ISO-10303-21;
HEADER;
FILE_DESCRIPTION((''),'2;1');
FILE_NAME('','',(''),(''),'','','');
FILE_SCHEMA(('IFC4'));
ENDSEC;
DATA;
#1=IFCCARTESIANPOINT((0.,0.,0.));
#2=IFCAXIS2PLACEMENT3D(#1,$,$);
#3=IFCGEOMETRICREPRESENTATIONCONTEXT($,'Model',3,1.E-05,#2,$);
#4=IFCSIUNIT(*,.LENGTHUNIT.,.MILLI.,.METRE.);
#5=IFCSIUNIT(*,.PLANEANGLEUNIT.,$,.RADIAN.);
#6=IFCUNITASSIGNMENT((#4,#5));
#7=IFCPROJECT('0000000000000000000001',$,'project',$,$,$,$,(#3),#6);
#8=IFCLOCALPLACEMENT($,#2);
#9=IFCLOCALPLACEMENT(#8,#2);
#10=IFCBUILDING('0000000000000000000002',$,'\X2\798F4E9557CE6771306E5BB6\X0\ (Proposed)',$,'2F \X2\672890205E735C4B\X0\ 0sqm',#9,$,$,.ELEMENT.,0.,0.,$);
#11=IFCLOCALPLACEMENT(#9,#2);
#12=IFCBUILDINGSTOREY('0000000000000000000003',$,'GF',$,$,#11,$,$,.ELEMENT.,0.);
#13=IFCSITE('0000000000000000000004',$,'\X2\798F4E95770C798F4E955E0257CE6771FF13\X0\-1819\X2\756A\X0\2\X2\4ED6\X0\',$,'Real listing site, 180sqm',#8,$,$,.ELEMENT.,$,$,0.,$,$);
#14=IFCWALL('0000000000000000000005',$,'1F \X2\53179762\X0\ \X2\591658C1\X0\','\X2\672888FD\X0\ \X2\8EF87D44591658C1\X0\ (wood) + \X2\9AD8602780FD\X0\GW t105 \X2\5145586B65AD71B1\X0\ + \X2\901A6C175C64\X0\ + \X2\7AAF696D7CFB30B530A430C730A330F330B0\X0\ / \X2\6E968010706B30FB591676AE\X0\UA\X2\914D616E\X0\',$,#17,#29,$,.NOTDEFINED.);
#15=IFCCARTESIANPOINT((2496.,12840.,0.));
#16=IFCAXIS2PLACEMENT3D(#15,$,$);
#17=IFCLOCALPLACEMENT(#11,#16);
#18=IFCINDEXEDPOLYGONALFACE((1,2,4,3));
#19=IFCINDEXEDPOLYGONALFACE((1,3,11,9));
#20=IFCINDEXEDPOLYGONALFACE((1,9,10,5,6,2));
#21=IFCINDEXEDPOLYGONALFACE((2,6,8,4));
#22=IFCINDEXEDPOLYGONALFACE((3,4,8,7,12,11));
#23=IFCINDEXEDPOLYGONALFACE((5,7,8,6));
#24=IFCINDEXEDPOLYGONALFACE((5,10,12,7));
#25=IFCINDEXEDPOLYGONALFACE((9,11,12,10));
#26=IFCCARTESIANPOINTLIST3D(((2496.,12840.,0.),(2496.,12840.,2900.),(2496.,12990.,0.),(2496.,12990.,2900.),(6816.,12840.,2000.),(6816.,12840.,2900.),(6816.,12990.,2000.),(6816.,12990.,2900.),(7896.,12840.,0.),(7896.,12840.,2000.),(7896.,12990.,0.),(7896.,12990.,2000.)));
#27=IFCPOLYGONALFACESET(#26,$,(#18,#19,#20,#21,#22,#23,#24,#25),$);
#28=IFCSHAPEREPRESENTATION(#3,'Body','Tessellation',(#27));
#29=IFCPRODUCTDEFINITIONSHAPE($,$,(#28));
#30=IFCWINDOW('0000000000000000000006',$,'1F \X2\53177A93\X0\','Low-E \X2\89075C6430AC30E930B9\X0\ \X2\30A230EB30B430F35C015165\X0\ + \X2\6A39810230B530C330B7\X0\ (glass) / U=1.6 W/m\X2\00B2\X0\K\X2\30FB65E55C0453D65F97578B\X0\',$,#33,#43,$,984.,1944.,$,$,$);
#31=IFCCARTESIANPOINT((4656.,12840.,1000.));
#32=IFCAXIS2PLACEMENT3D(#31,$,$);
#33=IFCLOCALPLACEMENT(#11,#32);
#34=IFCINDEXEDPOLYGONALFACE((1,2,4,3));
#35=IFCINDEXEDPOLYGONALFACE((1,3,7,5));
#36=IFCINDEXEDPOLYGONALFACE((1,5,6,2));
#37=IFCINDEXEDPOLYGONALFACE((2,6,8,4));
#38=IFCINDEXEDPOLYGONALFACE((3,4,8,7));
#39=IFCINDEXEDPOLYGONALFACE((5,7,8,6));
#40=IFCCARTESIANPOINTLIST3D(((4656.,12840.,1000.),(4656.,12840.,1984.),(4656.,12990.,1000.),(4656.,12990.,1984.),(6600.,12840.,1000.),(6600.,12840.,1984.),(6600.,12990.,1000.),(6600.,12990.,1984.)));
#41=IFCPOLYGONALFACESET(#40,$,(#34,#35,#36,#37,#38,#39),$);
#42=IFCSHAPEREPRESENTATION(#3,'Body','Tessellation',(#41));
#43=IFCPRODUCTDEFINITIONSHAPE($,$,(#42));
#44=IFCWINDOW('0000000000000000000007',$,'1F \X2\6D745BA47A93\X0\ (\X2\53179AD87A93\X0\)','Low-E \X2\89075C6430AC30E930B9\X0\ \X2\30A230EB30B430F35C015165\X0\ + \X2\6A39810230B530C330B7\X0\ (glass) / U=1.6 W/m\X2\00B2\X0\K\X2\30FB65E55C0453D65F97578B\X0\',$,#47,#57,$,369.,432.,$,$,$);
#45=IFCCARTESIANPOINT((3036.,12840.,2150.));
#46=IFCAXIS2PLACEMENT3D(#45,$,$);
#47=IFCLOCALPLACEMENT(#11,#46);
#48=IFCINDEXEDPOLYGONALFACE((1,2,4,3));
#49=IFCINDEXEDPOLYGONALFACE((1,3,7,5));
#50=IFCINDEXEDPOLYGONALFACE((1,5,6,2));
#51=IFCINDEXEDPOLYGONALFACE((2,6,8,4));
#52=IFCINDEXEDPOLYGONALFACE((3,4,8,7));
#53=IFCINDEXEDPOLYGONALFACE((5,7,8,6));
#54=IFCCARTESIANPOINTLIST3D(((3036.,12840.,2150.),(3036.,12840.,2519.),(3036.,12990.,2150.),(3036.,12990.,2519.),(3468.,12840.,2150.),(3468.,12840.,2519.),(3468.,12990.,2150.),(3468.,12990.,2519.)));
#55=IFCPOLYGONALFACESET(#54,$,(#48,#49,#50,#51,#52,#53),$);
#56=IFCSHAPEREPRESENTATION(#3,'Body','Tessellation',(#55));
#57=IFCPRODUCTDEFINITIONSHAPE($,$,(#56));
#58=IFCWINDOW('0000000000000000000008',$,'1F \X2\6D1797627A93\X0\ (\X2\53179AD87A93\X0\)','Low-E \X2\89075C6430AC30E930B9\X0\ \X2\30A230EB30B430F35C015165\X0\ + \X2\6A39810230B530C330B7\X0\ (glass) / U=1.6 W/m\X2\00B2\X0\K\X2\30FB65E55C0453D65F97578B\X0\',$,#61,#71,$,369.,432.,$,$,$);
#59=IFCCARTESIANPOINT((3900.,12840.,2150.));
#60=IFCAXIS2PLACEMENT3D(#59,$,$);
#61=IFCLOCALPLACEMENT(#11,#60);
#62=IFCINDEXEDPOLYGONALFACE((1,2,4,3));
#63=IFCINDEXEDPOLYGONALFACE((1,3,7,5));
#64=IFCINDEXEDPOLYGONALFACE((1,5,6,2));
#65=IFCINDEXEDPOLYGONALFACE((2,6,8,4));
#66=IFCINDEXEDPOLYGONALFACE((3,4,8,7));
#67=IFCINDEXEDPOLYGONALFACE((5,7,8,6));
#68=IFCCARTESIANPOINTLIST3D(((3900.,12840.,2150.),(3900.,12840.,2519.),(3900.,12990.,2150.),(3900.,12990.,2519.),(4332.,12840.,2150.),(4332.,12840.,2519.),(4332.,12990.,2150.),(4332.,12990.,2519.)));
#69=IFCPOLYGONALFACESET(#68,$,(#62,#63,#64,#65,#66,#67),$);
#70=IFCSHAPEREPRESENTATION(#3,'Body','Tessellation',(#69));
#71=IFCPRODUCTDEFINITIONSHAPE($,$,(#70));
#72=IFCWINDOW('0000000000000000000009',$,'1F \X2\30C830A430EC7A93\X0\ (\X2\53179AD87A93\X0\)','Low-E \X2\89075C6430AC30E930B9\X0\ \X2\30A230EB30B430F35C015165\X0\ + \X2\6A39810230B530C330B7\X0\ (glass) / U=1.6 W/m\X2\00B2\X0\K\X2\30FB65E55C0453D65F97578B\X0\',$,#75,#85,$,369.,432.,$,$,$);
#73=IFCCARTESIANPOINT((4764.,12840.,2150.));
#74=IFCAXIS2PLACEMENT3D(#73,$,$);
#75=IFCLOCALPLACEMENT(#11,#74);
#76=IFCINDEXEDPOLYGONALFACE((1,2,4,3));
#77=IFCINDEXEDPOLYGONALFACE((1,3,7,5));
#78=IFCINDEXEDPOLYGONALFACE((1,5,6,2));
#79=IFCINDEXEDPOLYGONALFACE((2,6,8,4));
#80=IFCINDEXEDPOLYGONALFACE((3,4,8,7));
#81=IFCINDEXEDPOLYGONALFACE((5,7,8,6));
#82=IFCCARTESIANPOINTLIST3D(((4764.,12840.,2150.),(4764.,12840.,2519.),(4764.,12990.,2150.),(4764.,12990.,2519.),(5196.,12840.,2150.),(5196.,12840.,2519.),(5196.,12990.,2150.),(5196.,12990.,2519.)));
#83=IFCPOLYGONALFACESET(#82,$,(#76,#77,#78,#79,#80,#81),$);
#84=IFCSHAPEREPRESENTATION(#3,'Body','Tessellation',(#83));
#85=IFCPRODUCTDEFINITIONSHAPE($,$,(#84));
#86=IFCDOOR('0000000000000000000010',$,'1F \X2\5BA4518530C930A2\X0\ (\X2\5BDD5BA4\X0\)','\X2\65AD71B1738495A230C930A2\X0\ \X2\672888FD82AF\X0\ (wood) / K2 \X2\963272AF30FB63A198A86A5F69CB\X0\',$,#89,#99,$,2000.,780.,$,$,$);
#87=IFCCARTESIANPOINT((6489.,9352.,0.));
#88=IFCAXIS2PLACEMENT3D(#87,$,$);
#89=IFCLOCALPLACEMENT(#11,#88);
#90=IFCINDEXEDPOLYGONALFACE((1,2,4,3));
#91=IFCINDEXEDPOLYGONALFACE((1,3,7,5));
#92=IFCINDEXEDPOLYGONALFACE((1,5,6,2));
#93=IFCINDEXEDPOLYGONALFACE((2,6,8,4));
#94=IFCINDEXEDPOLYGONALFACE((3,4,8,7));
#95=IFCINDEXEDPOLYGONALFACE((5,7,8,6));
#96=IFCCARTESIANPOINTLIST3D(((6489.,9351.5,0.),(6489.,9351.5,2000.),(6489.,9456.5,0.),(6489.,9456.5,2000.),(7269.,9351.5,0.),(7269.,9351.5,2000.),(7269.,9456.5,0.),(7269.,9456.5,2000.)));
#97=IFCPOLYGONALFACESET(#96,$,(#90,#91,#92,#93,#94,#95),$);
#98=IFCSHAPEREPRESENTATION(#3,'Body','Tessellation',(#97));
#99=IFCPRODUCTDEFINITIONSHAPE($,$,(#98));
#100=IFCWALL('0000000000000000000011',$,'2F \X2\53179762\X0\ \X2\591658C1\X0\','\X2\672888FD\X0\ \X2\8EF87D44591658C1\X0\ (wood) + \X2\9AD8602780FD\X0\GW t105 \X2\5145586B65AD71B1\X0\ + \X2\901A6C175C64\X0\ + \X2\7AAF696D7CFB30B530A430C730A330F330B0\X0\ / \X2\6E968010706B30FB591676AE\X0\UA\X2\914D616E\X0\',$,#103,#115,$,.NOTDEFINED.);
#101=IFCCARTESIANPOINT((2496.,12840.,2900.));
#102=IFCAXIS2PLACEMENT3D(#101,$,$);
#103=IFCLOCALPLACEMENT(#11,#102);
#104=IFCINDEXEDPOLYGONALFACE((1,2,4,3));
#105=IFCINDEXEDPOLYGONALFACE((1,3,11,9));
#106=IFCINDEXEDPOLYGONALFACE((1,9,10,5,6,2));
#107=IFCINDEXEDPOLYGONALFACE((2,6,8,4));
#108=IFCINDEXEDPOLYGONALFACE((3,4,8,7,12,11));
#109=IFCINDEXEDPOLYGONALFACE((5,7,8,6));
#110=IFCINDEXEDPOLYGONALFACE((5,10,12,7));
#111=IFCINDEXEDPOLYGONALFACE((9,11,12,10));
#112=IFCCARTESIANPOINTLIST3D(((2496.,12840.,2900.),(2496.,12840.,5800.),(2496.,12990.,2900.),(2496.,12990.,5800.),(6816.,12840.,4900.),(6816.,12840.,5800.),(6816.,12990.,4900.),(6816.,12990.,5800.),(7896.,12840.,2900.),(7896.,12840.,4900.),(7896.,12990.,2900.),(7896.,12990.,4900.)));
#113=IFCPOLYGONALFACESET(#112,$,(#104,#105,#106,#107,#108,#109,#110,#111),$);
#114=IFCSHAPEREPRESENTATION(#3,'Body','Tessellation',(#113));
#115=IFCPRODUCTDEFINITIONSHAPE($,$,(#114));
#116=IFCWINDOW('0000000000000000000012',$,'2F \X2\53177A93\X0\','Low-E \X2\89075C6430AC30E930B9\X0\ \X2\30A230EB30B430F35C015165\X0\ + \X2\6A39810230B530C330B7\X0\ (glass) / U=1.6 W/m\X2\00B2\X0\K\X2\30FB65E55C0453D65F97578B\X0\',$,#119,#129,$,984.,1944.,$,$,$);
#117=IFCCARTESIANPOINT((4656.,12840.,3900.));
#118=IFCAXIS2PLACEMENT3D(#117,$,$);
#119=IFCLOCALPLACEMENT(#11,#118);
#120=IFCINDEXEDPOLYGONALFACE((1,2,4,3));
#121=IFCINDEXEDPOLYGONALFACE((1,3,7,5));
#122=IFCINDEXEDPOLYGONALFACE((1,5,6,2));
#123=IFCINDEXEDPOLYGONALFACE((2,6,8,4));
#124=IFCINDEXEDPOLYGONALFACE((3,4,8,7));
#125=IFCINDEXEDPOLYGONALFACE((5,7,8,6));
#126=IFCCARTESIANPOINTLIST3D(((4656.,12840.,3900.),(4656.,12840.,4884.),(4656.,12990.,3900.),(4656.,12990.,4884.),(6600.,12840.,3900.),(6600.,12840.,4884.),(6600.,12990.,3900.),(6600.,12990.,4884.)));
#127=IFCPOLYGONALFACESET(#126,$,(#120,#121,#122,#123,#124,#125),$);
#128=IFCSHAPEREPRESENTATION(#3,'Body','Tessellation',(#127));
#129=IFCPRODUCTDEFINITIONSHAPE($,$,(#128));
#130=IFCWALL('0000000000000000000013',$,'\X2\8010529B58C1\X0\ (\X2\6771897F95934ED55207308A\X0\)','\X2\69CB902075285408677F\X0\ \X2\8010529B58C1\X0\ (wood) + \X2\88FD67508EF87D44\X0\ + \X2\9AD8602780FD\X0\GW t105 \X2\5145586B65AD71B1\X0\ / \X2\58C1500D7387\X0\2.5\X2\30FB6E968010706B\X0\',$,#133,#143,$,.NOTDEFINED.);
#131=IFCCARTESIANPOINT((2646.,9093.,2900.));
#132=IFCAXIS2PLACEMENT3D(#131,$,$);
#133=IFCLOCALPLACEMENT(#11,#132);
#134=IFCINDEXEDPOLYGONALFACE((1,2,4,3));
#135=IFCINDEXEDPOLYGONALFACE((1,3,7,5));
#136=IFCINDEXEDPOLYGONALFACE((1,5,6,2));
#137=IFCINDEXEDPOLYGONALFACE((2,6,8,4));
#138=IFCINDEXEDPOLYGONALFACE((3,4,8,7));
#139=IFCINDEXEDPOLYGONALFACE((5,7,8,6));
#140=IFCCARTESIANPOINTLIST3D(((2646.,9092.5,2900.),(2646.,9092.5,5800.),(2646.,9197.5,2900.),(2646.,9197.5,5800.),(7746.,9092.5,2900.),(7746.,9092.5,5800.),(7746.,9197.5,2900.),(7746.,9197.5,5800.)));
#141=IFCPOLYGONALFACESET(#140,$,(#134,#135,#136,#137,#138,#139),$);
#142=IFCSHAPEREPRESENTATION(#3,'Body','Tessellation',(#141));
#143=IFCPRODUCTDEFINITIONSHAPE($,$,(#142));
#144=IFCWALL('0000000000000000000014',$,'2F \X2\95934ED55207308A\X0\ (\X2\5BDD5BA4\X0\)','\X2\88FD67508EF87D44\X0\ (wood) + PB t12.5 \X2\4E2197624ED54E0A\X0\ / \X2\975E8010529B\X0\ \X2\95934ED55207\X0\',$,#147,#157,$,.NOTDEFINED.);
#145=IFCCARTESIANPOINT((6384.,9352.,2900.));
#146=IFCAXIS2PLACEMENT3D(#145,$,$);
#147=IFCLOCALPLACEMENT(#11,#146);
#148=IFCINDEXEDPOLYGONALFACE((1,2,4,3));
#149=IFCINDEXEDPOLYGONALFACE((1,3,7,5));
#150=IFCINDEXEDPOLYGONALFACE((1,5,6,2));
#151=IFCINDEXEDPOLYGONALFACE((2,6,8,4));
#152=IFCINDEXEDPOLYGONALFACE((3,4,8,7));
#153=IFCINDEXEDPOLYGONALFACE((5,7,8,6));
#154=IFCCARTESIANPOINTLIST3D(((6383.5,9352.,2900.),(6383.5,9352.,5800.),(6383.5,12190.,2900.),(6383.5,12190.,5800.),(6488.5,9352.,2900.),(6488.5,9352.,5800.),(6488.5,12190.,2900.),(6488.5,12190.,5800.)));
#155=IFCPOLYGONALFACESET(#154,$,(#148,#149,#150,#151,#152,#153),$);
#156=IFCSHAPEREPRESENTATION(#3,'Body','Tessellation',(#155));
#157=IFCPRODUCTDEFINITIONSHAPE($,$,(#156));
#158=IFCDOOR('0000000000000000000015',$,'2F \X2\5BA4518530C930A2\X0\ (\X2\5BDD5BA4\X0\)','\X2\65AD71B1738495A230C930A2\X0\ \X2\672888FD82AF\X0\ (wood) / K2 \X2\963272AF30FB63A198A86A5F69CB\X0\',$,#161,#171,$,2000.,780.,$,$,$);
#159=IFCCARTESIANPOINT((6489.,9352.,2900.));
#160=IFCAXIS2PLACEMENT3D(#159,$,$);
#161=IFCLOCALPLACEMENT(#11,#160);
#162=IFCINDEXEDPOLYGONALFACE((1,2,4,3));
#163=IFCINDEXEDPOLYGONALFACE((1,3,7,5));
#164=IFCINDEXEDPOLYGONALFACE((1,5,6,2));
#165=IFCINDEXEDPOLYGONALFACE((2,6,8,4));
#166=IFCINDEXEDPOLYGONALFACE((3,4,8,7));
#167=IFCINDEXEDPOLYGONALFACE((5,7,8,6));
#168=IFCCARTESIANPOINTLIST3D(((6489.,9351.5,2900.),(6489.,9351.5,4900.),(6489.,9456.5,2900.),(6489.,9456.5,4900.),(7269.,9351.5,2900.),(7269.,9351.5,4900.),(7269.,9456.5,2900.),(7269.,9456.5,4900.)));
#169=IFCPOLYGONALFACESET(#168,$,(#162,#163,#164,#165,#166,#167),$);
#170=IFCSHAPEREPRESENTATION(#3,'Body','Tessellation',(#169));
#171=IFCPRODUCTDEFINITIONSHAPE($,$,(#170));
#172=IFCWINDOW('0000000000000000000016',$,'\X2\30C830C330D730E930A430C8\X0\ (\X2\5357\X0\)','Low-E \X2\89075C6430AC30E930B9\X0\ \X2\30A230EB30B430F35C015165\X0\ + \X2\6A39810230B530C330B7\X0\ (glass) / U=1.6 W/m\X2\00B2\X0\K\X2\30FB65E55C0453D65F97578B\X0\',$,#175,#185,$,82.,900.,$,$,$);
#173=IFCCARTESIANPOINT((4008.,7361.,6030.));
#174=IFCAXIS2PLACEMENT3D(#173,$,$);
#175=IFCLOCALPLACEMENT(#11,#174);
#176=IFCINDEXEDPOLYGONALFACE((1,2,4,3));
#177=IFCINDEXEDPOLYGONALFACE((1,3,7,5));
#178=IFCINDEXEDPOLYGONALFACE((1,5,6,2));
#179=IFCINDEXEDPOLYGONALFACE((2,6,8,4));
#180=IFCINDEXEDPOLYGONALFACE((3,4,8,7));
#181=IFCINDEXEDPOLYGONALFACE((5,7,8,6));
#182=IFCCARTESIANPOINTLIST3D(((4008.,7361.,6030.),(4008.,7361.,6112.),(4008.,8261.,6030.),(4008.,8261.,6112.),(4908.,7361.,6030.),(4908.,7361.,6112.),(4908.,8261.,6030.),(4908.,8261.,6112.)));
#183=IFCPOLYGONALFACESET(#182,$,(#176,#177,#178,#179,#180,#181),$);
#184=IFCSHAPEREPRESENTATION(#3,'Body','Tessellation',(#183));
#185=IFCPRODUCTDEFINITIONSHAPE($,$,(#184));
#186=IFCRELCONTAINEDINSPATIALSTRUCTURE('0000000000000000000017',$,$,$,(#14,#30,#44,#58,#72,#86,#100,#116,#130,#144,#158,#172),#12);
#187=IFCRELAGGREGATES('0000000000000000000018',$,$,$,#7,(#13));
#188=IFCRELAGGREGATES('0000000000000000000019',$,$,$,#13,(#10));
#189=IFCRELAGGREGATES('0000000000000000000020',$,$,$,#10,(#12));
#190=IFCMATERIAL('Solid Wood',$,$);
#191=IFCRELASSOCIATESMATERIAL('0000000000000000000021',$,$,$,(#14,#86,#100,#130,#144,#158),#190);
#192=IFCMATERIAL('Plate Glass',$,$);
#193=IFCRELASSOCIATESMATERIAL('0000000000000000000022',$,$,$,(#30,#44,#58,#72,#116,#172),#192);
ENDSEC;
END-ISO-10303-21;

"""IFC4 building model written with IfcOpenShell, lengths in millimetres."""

from ifc_helpers import new_model, si_unit, frame, frame_2d, origin, place, context, project, spatial, rectangle, extrude, material, element, fill, save


model = new_model("IFC4")

# Units and contexts
model_context = context("Model", 3, precision=1e-05, world=origin())
ifc_project = project(units=[si_unit("LENGTHUNIT", "METRE", prefix="MILLI"), si_unit("PLANEANGLEUNIT", "RADIAN")], contexts=[model_context])

# Site, building, storey
site_placement = place(None, origin())
site = spatial("IfcSite", under=ifc_project, at=site_placement, Name="福井県福井市城東３-1819番2他", ObjectType="Real listing site, 180sqm", CompositionType="ELEMENT", RefElevation=0.0)
building_placement = place(site_placement, origin())
building = spatial("IfcBuilding", under=site, at=building_placement, Name="福井城東の家 (Proposed)", ObjectType="2F 木造平屋 0sqm", CompositionType="ELEMENT", ElevationOfRefHeight=0.0, ElevationOfTerrain=0.0)
storey_placement = place(building_placement, origin())
storey = spatial("IfcBuildingStorey", under=building, at=storey_placement, Name="GF", CompositionType="ELEMENT", Elevation=0.0)

# Wall, openings, windows
ifc_material_1 = material(Name="Solid Wood")
wall_1_placement = place(storey_placement, frame((2496.0, 12840.0, 0.0)))
wall_1 = element("IfcWall", 1, at=wall_1_placement, inside=storey, material=ifc_material_1, Name="1F 北面 外壁", Description="木製 軸組外壁 (wood) + 高性能GW t105 充填断熱 + 通気層 + 窯業系サイディング / 準耐火・外皮UA配慮", PredefinedType="NOTDEFINED", context=model_context, shape_type="SweptSolid", body=[
    extrude(rectangle(XDim=5400.0, YDim=150.0, at=frame_2d((2700.0, 75.0))), frame((2496.0, 12840.0, 0.0)), (0.0, 0.0, 1.0), 2900.0),
])
opening_1_placement = place(storey_placement, frame((4656.0, 12840.0, 1000.0)))
opening_1 = element("IfcOpeningElement", 2, at=opening_1_placement, cuts=wall_1, PredefinedType="NOTDEFINED", context=model_context, shape_type="SweptSolid", body=[
    extrude(rectangle(XDim=1944.0, YDim=150.0, at=frame_2d((972.0, 75.0))), frame((4656.0, 12840.0, 1000.0)), (0.0, 0.0, 1.0), 984.0),
])
opening_2_placement = place(storey_placement, frame((3036.0, 12840.0, 2150.0)))
opening_2 = element("IfcOpeningElement", 3, at=opening_2_placement, cuts=wall_1, PredefinedType="NOTDEFINED", context=model_context, shape_type="SweptSolid", body=[
    extrude(rectangle(XDim=432.0, YDim=150.0, at=frame_2d((216.0, 75.0))), frame((3036.0, 12840.0, 2150.0)), (0.0, 0.0, 1.0), 369.0),
])
opening_3_placement = place(storey_placement, frame((3900.0, 12840.0, 2150.0)))
opening_3 = element("IfcOpeningElement", 4, at=opening_3_placement, cuts=wall_1, PredefinedType="NOTDEFINED", context=model_context, shape_type="SweptSolid", body=[
    extrude(rectangle(XDim=432.0, YDim=150.0, at=frame_2d((216.0, 75.0))), frame((3900.0, 12840.0, 2150.0)), (0.0, 0.0, 1.0), 369.0),
])
opening_4_placement = place(storey_placement, frame((4764.0, 12840.0, 2150.0)))
opening_4 = element("IfcOpeningElement", 5, at=opening_4_placement, cuts=wall_1, PredefinedType="NOTDEFINED", context=model_context, shape_type="SweptSolid", body=[
    extrude(rectangle(XDim=432.0, YDim=150.0, at=frame_2d((216.0, 75.0))), frame((4764.0, 12840.0, 2150.0)), (0.0, 0.0, 1.0), 369.0),
])
ifc_material_2 = material(Name="Plate Glass")
window_1_placement = place(storey_placement, frame((4656.0, 12840.0, 1000.0)))
window_1 = element("IfcWindow", 6, at=window_1_placement, inside=storey, material=ifc_material_2, Name="1F 北窓", Description="Low-E 複層ガラス アルゴン封入 + 樹脂サッシ (glass) / U=1.6 W/m²K・日射取得型", OverallHeight=984.0, OverallWidth=1944.0, context=model_context, shape_type="SweptSolid", body=[
    extrude(rectangle(XDim=1944.0, YDim=150.0, at=frame_2d((972.0, 75.0))), frame((4656.0, 12840.0, 1000.0)), (0.0, 0.0, 1.0), 984.0),
])
fill(opening_1, window_1)
window_2_placement = place(storey_placement, frame((3036.0, 12840.0, 2150.0)))
window_2 = element("IfcWindow", 7, at=window_2_placement, inside=storey, material=ifc_material_2, Name="1F 浴室窓 (北高窓)", Description="Low-E 複層ガラス アルゴン封入 + 樹脂サッシ (glass) / U=1.6 W/m²K・日射取得型", OverallHeight=369.0, OverallWidth=432.0, context=model_context, shape_type="SweptSolid", body=[
    extrude(rectangle(XDim=432.0, YDim=150.0, at=frame_2d((216.0, 75.0))), frame((3036.0, 12840.0, 2150.0)), (0.0, 0.0, 1.0), 369.0),
])
fill(opening_2, window_2)
window_3_placement = place(storey_placement, frame((3900.0, 12840.0, 2150.0)))
window_3 = element("IfcWindow", 8, at=window_3_placement, inside=storey, material=ifc_material_2, Name="1F 洗面窓 (北高窓)", Description="Low-E 複層ガラス アルゴン封入 + 樹脂サッシ (glass) / U=1.6 W/m²K・日射取得型", OverallHeight=369.0, OverallWidth=432.0, context=model_context, shape_type="SweptSolid", body=[
    extrude(rectangle(XDim=432.0, YDim=150.0, at=frame_2d((216.0, 75.0))), frame((3900.0, 12840.0, 2150.0)), (0.0, 0.0, 1.0), 369.0),
])
fill(opening_3, window_3)
window_4_placement = place(storey_placement, frame((4764.0, 12840.0, 2150.0)))
window_4 = element("IfcWindow", 9, at=window_4_placement, inside=storey, material=ifc_material_2, Name="1F トイレ窓 (北高窓)", Description="Low-E 複層ガラス アルゴン封入 + 樹脂サッシ (glass) / U=1.6 W/m²K・日射取得型", OverallHeight=369.0, OverallWidth=432.0, context=model_context, shape_type="SweptSolid", body=[
    extrude(rectangle(XDim=432.0, YDim=150.0, at=frame_2d((216.0, 75.0))), frame((4764.0, 12840.0, 2150.0)), (0.0, 0.0, 1.0), 369.0),
])
fill(opening_4, window_4)

# Door
door_1_placement = place(storey_placement, frame((6489.0, 9352.0, 0.0)))
element("IfcDoor", 10, at=door_1_placement, inside=storey, material=ifc_material_1, Name="1F 室内ドア (寝室)", Description="断熱玄関ドア 木製芯 (wood) / K2 防犯・採風機構", OverallHeight=2000.0, OverallWidth=780.0, context=model_context, shape_type="SweptSolid", body=[
    extrude(rectangle(XDim=780.0, YDim=105.0, at=frame_2d((390.0, 52.0))), frame((6489.0, 9352.0, 0.0)), (0.0, 0.0, 1.0), 2000.0),
])

# Wall, opening, window
wall_2_placement = place(storey_placement, frame((2496.0, 12840.0, 2900.0)))
wall_2 = element("IfcWall", 11, at=wall_2_placement, inside=storey, material=ifc_material_1, Name="2F 北面 外壁", Description="木製 軸組外壁 (wood) + 高性能GW t105 充填断熱 + 通気層 + 窯業系サイディング / 準耐火・外皮UA配慮", PredefinedType="NOTDEFINED", context=model_context, shape_type="SweptSolid", body=[
    extrude(rectangle(XDim=5400.0, YDim=150.0, at=frame_2d((2700.0, 75.0))), frame((2496.0, 12840.0, 2900.0)), (0.0, 0.0, 1.0), 2900.0),
])
opening_5_placement = place(storey_placement, frame((4656.0, 12840.0, 3900.0)))
opening_5 = element("IfcOpeningElement", 12, at=opening_5_placement, cuts=wall_2, PredefinedType="NOTDEFINED", context=model_context, shape_type="SweptSolid", body=[
    extrude(rectangle(XDim=1944.0, YDim=150.0, at=frame_2d((972.0, 75.0))), frame((4656.0, 12840.0, 3900.0)), (0.0, 0.0, 1.0), 984.0),
])
window_5_placement = place(storey_placement, frame((4656.0, 12840.0, 3900.0)))
window_5 = element("IfcWindow", 13, at=window_5_placement, inside=storey, material=ifc_material_2, Name="2F 北窓", Description="Low-E 複層ガラス アルゴン封入 + 樹脂サッシ (glass) / U=1.6 W/m²K・日射取得型", OverallHeight=984.0, OverallWidth=1944.0, context=model_context, shape_type="SweptSolid", body=[
    extrude(rectangle(XDim=1944.0, YDim=150.0, at=frame_2d((972.0, 75.0))), frame((4656.0, 12840.0, 3900.0)), (0.0, 0.0, 1.0), 984.0),
])
fill(opening_5, window_5)

# Walls
wall_3_placement = place(storey_placement, frame((2646.0, 9093.0, 2900.0)))
element("IfcWall", 14, at=wall_3_placement, inside=storey, material=ifc_material_1, Name="耐力壁 (東西間仕切り)", Description="構造用合板 耐力壁 (wood) + 製材軸組 + 高性能GW t105 充填断熱 / 壁倍率2.5・準耐火", PredefinedType="NOTDEFINED", context=model_context, shape_type="SweptSolid", body=[
    extrude(rectangle(XDim=5100.0, YDim=105.0, at=frame_2d((2550.0, 52.0))), frame((2646.0, 9093.0, 2900.0)), (0.0, 0.0, 1.0), 2900.0),
])
wall_4_placement = place(storey_placement, frame((6384.0, 9352.0, 2900.0)))
element("IfcWall", 15, at=wall_4_placement, inside=storey, material=ifc_material_1, Name="2F 間仕切り (寝室)", Description="製材軸組 (wood) + PB t12.5 両面仕上 / 非耐力 間仕切", PredefinedType="NOTDEFINED", context=model_context, shape_type="SweptSolid", body=[
    extrude(rectangle(XDim=105.0, YDim=2838.0, at=frame_2d((52.0, 1419.0))), frame((6384.0, 9352.0, 2900.0)), (0.0, 0.0, 1.0), 2900.0),
])

# Door
door_2_placement = place(storey_placement, frame((6489.0, 9352.0, 2900.0)))
element("IfcDoor", 16, at=door_2_placement, inside=storey, material=ifc_material_1, Name="2F 室内ドア (寝室)", Description="断熱玄関ドア 木製芯 (wood) / K2 防犯・採風機構", OverallHeight=2000.0, OverallWidth=780.0, context=model_context, shape_type="SweptSolid", body=[
    extrude(rectangle(XDim=780.0, YDim=105.0, at=frame_2d((390.0, 52.0))), frame((6489.0, 9352.0, 2900.0)), (0.0, 0.0, 1.0), 2000.0),
])

# Window
window_6_placement = place(storey_placement, frame((4008.0, 7361.0, 6030.0)))
element("IfcWindow", 17, at=window_6_placement, inside=storey, material=ifc_material_2, Name="トップライト (南)", Description="Low-E 複層ガラス アルゴン封入 + 樹脂サッシ (glass) / U=1.6 W/m²K・日射取得型", OverallHeight=82.0, OverallWidth=900.0, context=model_context, shape_type="SweptSolid", body=[
    extrude(rectangle(XDim=900.0, YDim=900.0, at=frame_2d((450.0, 450.0))), frame((4008.0, 7361.0, 6030.0)), (0.0, 0.0, 1.0), 82.0),
])

save(model, "model.ifc")
